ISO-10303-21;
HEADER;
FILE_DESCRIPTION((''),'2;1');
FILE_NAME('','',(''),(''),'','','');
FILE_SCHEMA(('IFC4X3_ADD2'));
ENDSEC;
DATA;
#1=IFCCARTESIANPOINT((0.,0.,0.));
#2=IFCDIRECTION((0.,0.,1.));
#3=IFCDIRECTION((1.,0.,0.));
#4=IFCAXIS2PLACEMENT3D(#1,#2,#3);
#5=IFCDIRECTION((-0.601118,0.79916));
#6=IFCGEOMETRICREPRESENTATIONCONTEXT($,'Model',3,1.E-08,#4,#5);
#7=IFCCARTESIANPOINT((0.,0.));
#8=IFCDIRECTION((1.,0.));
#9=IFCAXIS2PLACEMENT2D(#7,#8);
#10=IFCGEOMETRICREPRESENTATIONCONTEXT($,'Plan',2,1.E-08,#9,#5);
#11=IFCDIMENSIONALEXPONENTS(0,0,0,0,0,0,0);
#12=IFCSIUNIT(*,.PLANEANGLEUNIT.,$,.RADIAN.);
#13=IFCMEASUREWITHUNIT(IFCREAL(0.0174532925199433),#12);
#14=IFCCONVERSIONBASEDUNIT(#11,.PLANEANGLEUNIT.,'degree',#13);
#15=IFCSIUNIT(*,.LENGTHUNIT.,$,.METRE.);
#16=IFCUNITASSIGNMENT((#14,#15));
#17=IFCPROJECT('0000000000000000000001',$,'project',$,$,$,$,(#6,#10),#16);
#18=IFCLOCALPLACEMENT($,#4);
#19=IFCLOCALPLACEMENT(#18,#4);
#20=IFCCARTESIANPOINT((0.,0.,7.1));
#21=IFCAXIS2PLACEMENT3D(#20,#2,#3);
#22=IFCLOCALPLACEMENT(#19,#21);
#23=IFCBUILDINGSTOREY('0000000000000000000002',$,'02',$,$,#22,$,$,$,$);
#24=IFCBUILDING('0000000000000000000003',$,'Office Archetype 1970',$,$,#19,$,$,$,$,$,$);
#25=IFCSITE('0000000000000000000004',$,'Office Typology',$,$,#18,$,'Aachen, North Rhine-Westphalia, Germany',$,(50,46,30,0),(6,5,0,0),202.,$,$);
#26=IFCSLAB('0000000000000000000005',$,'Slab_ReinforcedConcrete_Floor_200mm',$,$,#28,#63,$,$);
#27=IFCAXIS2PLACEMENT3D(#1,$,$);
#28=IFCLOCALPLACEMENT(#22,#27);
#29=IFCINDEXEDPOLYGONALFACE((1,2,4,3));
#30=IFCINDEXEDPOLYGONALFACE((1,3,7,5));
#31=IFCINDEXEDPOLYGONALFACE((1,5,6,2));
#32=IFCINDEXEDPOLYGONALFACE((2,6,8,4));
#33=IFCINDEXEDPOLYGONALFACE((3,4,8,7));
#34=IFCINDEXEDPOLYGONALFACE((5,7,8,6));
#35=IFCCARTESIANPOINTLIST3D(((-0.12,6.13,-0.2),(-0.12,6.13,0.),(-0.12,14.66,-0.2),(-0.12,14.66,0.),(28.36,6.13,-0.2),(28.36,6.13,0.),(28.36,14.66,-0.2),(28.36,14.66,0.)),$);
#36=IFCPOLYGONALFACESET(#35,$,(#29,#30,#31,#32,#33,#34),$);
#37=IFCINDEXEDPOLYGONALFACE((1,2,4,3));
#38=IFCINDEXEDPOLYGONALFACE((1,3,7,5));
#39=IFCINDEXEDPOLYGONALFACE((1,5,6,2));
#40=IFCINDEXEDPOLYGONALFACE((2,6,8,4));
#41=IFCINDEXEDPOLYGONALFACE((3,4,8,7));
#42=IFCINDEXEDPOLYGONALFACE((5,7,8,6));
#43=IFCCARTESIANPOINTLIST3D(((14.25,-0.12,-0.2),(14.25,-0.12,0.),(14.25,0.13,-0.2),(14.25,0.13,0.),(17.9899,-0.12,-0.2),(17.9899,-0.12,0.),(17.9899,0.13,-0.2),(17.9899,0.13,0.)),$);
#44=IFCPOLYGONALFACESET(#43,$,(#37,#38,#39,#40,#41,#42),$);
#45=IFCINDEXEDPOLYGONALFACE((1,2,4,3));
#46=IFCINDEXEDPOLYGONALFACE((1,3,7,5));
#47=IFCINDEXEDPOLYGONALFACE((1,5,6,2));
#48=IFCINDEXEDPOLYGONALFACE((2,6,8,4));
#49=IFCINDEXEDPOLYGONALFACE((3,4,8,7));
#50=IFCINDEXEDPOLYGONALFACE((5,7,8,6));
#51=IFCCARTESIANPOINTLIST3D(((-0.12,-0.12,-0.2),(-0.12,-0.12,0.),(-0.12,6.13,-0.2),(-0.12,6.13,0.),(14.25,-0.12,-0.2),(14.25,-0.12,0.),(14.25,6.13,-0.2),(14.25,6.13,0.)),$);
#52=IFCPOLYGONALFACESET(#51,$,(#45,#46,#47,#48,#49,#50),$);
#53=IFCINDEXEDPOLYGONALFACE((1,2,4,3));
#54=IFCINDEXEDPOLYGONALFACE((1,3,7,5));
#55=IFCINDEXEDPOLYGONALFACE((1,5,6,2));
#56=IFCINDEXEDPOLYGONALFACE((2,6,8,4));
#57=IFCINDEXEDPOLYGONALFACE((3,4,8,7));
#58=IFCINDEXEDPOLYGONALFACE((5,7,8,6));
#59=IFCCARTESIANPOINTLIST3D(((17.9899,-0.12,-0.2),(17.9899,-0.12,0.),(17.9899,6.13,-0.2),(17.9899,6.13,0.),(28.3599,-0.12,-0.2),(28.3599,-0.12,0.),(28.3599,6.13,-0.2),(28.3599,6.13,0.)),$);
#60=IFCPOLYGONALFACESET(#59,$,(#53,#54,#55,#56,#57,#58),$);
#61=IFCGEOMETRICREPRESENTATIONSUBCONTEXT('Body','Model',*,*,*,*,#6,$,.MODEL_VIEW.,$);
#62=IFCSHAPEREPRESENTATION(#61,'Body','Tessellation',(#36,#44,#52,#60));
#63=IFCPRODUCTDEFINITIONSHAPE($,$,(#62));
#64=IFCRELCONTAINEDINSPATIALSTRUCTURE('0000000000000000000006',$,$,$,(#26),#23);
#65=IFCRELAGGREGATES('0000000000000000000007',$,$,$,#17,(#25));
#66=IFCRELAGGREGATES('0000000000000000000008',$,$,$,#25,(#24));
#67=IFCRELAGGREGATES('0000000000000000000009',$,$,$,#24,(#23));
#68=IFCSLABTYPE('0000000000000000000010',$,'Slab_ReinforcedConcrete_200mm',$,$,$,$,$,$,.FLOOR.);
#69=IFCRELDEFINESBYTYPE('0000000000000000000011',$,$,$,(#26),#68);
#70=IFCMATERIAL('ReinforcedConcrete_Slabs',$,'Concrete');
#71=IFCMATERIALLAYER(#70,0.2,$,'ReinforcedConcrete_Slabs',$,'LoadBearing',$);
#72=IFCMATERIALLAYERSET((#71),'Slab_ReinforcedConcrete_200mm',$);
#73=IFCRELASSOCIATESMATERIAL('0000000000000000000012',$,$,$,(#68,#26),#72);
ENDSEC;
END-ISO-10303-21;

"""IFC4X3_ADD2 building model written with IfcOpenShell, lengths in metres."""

from ifc_helpers import new_model, entity, si_unit, converted_unit, direction, frame, origin_with_axes, origin_2d_with_axis, place, context, subcontext, project, spatial, indexed_curve, outline, extrude, material, layer, layer_set, layer_usage, type_object, element, save


model = new_model("IFC4X3_ADD2")

# Units and contexts
model_context = context("Model", 3, precision=1e-08, world=origin_with_axes(), true_north=direction((-0.601118, 0.79916)))
plan_context = context("Plan", 2, precision=1e-08, world=origin_2d_with_axis(), true_north=direction((-0.601118, 0.79916)))
body_context = subcontext(model_context, "Body", "Model", "MODEL_VIEW")
ifc_project = project(units=[converted_unit("PLANEANGLEUNIT", "degree", entity("IfcReal", 0.0174532925199433), si_unit("PLANEANGLEUNIT", "RADIAN"), dimensions=[0, 0, 0, 0, 0, 0, 0]), si_unit("LENGTHUNIT", "METRE")], contexts=[model_context, plan_context])

# Site, building, storey
site_placement = place(None, origin_with_axes())
site = spatial("IfcSite", under=ifc_project, at=site_placement, Name="Office Typology", LongName="Aachen, North Rhine-Westphalia, Germany", RefLatitude=(50, 46, 30, 0), RefLongitude=(6, 5, 0, 0), RefElevation=202.0)
building_placement = place(site_placement, origin_with_axes())
building = spatial("IfcBuilding", under=site, at=building_placement, Name="Office Archetype 1970")
storey_placement = place(building_placement, frame((0.0, 0.0, 7.1), z_axis=(0.0, 0.0, 1.0), x_axis=(1.0, 0.0, 0.0)))
storey = spatial("IfcBuildingStorey", under=building, at=storey_placement, Name="02")

# Slab
ifc_material_1 = material(Name="ReinforcedConcrete_Slabs", Category="Concrete")
ifc_layer_1 = layer(ifc_material_1, 0.2, Name="ReinforcedConcrete_Slabs", Category="LoadBearing")
ifc_layer_set_1 = layer_set([ifc_layer_1], Name="Slab_ReinforcedConcrete_200mm")
slab_type_1 = type_object("IfcSlabType", Name="Slab_ReinforcedConcrete_200mm", PredefinedType="FLOOR", material=ifc_layer_set_1)
ifc_layer_usage_1 = layer_usage(ifc_layer_set_1, "AXIS3", "POSITIVE", 0.0)
slab_1_placement = place(storey_placement, frame((17.9899, 6.13, 0.0), z_axis=(0.0, 0.0, 1.0), x_axis=(1.0, 0.0, 0.0)))
element("IfcSlab", 1, at=slab_1_placement, inside=storey, type_object=slab_type_1, material=ifc_layer_usage_1, Name="Slab_ReinforcedConcrete_Floor_200mm", context=body_context, shape_type="SweptSolid", body=[
    extrude(outline(indexed_curve([(0.0, 0.0), (28.48, 0.0), (28.48, -8.53), (0.0, -8.53), (0.0, 0.0)])), frame((-18.1099, 8.53, -0.2), z_axis=(0.0, 0.0, 1.0), x_axis=(1.0, 0.0, 0.0)), (0.0, 0.0, 1.0), 0.2),
    extrude(outline(indexed_curve([(0.0, 0.0), (3.7399, 0.0), (3.7399, 0.25), (0.0, 0.25), (0.0, 0.0)])), frame((-3.7399, -6.25, -0.2), z_axis=(0.0, 0.0, 1.0), x_axis=(1.0, 0.0, 0.0)), (0.0, 0.0, 1.0), 0.2),
    extrude(outline(indexed_curve([(0.0, 0.0), (14.37, 0.0), (14.37, -6.25), (0.0, -6.25), (0.0, 0.0)])), frame((-18.1099, 0.0, -0.2), z_axis=(0.0, 0.0, 1.0), x_axis=(1.0, 0.0, 0.0)), (0.0, 0.0, 1.0), 0.2),
    extrude(outline(indexed_curve([(0.0, 0.0), (0.0, -6.25), (10.37, -6.25), (10.37, 0.0), (0.0, 0.0)])), frame((0.0, 0.0, -0.2), z_axis=(0.0, 0.0, 1.0), x_axis=(1.0, 0.0, 0.0)), (0.0, 0.0, 1.0), 0.2),
])

save(model, "model.ifc")
